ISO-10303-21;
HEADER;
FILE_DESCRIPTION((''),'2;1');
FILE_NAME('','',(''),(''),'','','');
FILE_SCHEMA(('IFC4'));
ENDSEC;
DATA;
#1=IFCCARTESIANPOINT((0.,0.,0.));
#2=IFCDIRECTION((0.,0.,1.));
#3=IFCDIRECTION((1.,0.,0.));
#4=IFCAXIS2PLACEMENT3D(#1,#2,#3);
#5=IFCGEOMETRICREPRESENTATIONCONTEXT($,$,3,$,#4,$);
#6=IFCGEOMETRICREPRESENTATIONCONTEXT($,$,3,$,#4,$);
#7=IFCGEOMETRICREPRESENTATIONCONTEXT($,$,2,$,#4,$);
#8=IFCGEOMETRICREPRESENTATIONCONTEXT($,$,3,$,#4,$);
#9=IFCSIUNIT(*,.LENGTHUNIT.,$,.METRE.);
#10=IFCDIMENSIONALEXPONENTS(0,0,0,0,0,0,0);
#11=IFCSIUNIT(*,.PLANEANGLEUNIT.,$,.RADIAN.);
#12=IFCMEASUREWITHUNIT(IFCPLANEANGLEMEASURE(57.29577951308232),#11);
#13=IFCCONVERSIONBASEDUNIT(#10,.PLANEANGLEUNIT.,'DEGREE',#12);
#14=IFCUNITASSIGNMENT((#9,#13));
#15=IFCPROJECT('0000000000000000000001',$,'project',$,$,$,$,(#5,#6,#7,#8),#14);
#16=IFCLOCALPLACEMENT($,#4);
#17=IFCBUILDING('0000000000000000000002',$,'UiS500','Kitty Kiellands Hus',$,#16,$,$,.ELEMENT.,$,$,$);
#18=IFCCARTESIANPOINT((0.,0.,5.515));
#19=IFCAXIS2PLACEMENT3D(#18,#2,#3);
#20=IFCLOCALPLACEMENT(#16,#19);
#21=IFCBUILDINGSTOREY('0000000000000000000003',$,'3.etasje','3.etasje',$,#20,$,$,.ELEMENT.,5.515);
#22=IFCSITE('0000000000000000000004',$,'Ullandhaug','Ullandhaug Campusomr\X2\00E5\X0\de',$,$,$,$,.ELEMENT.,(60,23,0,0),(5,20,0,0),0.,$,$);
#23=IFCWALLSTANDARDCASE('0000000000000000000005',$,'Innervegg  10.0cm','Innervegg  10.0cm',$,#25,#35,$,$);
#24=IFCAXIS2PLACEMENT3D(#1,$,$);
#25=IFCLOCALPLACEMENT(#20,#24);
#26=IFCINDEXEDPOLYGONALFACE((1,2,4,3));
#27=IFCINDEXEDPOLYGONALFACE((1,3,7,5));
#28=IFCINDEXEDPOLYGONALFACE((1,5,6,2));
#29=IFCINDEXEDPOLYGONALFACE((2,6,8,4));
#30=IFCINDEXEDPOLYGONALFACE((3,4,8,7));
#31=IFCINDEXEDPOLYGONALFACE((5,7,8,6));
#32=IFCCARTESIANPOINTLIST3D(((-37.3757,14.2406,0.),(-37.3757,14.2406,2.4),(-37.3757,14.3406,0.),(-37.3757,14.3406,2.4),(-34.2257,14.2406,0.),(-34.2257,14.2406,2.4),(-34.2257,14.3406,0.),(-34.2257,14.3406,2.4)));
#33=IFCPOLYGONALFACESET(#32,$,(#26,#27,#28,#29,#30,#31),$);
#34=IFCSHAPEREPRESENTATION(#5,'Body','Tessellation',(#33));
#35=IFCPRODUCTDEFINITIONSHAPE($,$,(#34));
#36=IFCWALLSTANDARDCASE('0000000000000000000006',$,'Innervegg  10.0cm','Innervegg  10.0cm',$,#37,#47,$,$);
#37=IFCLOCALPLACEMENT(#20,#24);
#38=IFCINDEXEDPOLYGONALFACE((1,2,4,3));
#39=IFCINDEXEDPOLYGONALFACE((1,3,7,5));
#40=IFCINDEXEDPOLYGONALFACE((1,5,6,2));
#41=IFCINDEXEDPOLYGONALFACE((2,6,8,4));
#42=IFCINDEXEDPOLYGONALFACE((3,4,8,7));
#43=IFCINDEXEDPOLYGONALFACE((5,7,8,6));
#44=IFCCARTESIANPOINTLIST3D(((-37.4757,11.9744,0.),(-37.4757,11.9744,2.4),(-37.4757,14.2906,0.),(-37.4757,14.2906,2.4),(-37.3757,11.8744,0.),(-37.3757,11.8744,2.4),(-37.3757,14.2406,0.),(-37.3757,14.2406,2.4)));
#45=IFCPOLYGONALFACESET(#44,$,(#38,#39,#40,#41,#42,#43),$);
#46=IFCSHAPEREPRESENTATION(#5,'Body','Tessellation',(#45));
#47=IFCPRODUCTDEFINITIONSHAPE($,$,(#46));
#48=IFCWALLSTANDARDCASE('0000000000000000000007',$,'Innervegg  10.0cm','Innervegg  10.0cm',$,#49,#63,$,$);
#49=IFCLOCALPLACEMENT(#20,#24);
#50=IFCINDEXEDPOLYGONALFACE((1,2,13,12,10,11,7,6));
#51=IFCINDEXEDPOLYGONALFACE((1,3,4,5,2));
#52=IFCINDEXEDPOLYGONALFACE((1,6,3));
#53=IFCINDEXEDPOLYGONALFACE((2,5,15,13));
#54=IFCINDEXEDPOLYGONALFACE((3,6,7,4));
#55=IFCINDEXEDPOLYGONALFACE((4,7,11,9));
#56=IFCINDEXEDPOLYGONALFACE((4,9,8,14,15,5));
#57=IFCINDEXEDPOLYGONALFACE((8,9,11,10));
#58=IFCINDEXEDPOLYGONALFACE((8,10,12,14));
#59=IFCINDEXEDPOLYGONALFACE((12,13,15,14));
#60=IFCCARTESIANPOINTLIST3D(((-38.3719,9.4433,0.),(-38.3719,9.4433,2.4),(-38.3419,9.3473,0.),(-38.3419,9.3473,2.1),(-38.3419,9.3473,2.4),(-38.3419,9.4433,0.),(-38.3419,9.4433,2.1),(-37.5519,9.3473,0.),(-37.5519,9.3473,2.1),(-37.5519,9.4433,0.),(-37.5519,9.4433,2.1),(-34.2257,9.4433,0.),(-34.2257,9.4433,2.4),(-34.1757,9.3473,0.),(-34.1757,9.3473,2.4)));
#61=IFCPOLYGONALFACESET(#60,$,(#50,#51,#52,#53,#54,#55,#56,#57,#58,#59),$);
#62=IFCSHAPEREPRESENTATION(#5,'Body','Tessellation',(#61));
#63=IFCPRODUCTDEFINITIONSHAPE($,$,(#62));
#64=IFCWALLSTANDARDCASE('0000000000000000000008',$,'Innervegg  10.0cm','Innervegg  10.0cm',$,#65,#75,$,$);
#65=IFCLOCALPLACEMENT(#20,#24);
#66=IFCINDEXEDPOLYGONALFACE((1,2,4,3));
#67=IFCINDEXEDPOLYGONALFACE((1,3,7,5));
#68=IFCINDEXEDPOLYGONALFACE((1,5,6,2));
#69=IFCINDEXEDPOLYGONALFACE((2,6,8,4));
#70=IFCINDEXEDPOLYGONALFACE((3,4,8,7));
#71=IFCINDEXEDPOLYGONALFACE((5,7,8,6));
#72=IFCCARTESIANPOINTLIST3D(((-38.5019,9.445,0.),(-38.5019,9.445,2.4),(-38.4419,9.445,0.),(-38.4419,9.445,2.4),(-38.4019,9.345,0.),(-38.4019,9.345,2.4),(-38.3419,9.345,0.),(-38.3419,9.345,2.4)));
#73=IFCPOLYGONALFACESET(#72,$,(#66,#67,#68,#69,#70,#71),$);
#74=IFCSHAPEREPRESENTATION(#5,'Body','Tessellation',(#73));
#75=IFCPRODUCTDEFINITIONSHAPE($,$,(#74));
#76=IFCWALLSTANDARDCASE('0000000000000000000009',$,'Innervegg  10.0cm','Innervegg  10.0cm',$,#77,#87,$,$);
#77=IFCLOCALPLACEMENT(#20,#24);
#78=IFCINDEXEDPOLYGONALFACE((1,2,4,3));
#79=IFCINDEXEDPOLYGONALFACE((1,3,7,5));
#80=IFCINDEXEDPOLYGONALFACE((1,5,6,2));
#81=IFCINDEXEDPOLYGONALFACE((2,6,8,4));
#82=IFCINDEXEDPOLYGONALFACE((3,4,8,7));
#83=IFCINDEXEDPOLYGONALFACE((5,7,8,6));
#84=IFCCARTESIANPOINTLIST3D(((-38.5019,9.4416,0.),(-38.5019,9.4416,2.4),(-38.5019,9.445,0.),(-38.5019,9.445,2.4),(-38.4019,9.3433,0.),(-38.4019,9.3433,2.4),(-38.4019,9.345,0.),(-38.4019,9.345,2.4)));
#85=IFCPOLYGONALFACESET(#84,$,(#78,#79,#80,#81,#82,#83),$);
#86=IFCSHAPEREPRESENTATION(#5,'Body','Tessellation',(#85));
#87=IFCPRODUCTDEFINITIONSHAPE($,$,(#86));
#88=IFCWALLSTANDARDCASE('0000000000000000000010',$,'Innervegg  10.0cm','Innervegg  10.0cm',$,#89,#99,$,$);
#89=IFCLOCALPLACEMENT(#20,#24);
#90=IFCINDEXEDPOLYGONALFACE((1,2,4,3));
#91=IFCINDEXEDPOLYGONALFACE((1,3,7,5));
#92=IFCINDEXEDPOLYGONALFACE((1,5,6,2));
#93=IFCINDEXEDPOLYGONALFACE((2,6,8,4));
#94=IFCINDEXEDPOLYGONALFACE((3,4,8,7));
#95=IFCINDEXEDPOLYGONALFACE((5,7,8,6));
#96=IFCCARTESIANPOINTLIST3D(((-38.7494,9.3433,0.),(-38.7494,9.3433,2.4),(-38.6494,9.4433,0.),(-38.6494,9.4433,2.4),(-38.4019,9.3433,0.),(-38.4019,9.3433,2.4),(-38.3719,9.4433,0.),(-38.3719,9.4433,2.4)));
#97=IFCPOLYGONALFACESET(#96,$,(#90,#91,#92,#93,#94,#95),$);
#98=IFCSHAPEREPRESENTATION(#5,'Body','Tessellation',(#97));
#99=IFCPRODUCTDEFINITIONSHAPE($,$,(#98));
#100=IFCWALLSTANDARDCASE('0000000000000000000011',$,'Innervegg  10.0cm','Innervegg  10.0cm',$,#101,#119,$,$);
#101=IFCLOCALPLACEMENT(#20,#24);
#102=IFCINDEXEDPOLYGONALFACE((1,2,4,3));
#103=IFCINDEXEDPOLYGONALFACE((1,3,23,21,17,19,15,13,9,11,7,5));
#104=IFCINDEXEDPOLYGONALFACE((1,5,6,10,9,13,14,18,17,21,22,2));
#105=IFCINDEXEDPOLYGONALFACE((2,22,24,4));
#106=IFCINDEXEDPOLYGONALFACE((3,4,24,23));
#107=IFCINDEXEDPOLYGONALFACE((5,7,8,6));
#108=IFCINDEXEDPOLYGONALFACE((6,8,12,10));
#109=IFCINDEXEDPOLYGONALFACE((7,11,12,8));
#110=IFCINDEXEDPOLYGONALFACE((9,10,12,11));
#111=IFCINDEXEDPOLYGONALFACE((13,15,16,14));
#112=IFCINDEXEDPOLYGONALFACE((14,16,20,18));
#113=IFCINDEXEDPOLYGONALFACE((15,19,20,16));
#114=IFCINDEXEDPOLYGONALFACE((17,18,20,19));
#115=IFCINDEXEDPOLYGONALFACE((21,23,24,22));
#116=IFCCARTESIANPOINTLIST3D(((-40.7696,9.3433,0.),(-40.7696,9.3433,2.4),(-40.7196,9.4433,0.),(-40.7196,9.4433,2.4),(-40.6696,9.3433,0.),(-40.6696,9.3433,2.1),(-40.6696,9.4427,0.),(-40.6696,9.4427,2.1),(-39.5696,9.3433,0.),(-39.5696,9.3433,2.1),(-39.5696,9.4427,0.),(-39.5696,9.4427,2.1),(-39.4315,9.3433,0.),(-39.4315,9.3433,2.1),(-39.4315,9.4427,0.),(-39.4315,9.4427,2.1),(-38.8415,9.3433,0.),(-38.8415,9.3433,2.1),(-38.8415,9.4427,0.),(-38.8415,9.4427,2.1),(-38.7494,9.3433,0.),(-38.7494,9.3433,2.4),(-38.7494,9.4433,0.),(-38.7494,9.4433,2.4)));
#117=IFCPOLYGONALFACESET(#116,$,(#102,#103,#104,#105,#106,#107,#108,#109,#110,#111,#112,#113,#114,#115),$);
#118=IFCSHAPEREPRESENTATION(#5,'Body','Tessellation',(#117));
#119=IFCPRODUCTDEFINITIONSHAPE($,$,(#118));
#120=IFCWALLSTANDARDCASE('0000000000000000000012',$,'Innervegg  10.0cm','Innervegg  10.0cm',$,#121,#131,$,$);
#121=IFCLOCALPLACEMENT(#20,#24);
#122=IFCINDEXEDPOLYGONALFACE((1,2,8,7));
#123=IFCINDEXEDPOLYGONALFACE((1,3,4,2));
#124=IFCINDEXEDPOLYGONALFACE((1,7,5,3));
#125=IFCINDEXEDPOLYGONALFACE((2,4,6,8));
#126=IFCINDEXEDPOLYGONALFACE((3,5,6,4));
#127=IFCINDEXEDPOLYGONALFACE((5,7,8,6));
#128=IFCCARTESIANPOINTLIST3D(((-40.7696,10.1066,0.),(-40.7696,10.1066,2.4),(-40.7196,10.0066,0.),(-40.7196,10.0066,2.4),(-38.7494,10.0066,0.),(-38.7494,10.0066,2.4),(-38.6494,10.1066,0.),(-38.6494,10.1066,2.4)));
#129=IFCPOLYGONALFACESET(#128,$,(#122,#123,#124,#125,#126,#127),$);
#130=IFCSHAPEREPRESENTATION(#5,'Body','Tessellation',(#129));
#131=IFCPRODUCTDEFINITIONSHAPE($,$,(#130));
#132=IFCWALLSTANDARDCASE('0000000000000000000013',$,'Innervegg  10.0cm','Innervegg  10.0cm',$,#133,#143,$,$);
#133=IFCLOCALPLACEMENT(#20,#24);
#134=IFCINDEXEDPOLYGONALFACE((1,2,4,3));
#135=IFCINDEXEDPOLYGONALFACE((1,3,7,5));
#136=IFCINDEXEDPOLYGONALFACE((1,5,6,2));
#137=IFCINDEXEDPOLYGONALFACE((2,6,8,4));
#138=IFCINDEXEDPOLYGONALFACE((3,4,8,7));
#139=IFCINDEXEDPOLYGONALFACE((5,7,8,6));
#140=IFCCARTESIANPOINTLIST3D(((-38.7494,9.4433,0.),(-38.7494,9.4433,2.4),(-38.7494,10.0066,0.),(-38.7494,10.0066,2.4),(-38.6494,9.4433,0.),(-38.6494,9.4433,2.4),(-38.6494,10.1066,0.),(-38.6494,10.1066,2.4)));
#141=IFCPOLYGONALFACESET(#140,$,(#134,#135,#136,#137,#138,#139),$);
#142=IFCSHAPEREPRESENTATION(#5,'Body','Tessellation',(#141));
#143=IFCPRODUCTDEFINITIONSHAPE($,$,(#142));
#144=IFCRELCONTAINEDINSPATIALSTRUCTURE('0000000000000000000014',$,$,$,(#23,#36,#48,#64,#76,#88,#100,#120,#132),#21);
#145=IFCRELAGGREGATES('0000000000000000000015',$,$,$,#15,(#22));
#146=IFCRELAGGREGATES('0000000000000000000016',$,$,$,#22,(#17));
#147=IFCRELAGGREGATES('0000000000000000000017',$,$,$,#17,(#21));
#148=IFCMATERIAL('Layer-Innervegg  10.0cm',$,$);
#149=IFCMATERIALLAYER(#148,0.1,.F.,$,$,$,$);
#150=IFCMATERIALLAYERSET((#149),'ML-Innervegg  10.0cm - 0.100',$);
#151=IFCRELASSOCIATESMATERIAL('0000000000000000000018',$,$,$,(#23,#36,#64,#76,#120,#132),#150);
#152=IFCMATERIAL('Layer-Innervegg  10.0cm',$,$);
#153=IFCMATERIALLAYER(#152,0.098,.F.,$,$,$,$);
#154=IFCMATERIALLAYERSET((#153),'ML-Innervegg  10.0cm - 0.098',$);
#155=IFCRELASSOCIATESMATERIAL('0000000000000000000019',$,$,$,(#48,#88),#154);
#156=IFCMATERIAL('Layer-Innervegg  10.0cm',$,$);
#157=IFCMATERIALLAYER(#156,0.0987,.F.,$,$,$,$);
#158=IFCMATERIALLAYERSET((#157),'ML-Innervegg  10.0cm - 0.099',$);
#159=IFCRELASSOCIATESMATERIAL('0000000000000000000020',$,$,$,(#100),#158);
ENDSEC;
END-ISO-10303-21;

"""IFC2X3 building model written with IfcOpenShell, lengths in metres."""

from ifc_helpers import new_model, entity, si_unit, converted_unit, frame, origin_with_axes, place, context, project, spatial, polyline, outline, extrude, material, layer, layer_set, layer_usage, element, save


model = new_model("IFC2X3")

# Units and contexts
context_of_model_1 = context(None, 3, world=origin_with_axes())
context_of_model_2 = context(None, 3, world=origin_with_axes())
context_of_model_3 = context(None, 2, world=origin_with_axes())
context_of_model_4 = context(None, 3, world=origin_with_axes())
ifc_project = project(units=[si_unit("LENGTHUNIT", "METRE"), converted_unit("PLANEANGLEUNIT", "DEGREE", entity("IfcPlaneAngleMeasure", 57.29577951308232), si_unit("PLANEANGLEUNIT", "RADIAN"), dimensions=[0, 0, 0, 0, 0, 0, 0])], contexts=[context_of_model_1, context_of_model_2, context_of_model_3, context_of_model_4])

# Site, building, storey
site = spatial("IfcSite", under=ifc_project, Name="Ullandhaug", Description="Ullandhaug Campusområde", CompositionType="ELEMENT", RefLatitude=(60, 23, 0, 0), RefLongitude=(5, 20, 0, 0), RefElevation=0.0)
building_placement = place(None, origin_with_axes())
building = spatial("IfcBuilding", under=site, at=building_placement, Name="UiS500", Description="Kitty Kiellands Hus", CompositionType="ELEMENT")
storey_placement = place(building_placement, frame((0.0, 0.0, 5.515), z_axis=(0.0, 0.0, 1.0), x_axis=(1.0, 0.0, 0.0)))
storey = spatial("IfcBuildingStorey", under=building, at=storey_placement, Name="3.etasje", Description="3.etasje", CompositionType="ELEMENT", Elevation=5.515)

# Shared definitions
ifc_material_1 = material(Name="Layer-Innervegg  10.0cm")
ifc_layer_1 = layer(ifc_material_1, 0.1, ventilated=False)
ifc_layer_set_1 = layer_set([ifc_layer_1], Name="ML-Innervegg  10.0cm - 0.100")
ifc_layer_usage_1 = layer_usage(ifc_layer_set_1, "AXIS2", "POSITIVE", 0.0)

# Walls
wall_1_placement = place(storey_placement, frame((-37.3757, 14.2406, 0.0), z_axis=(0.0, 0.0, 1.0), x_axis=(1.0, 0.0, 0.0)))
element("IfcWallStandardCase", 1, at=wall_1_placement, inside=storey, material=ifc_layer_usage_1, Name="Innervegg  10.0cm", Description="Innervegg  10.0cm", context=context_of_model_1, shape_type="SweptSolid", body=[
    extrude(outline(polyline([(0.0, 0.0), (3.15, 0.0), (3.15, 0.1), (0.0, 0.1), (0.0, 0.0)])), origin_with_axes(), (0.0, 0.0, 1.0), 2.4),
])
wall_2_placement = place(storey_placement, frame((-37.3757, 11.8744, 0.0), z_axis=(0.0, 0.0, 1.0), x_axis=(0.0, 1.0, 0.0)))
element("IfcWallStandardCase", 2, at=wall_2_placement, inside=storey, material=ifc_layer_usage_1, Name="Innervegg  10.0cm", Description="Innervegg  10.0cm", context=context_of_model_1, shape_type="SweptSolid", body=[
    extrude(outline(polyline([(0.0, 0.0), (2.3662, 0.0), (2.4162, 0.1), (0.1, 0.1), (0.0, 0.0)])), frame((0.0, 0.0, 0.0), z_axis=(0.0, 0.0, 1.0), x_axis=(1.0, 0.0, 0.0)), (0.0, 0.0, 1.0), 2.4),
])

# Wall, opening
ifc_material_2 = material(Name="Layer-Innervegg  10.0cm")
ifc_layer_2 = layer(ifc_material_2, 0.098, ventilated=False)
ifc_layer_set_2 = layer_set([ifc_layer_2], Name="ML-Innervegg  10.0cm - 0.098")
ifc_layer_usage_2 = layer_usage(ifc_layer_set_2, "AXIS2", "POSITIVE", 0.0)
wall_3_placement = place(storey_placement, frame((-34.2257, 9.4433, 0.0), z_axis=(0.0, 0.0, 1.0), x_axis=(-1.0, 0.0, 0.0)))
wall_3 = element("IfcWallStandardCase", 3, at=wall_3_placement, inside=storey, material=ifc_layer_usage_2, Name="Innervegg  10.0cm", Description="Innervegg  10.0cm", context=context_of_model_1, shape_type="SweptSolid", body=[
    extrude(outline(polyline([(0.0, 0.0), (4.1462, 0.0), (4.1162, 0.096), (-0.05, 0.096), (0.0, 0.0)])), frame((0.0, 0.0, 0.0), z_axis=(0.0, 0.0, 1.0), x_axis=(1.0, 0.0, 0.0)), (0.0, 0.0, 1.0), 2.4),
])
opening_1_placement = place(wall_3_placement, frame((3.3262, 0.096, 0.0), z_axis=(0.0, 0.0, 1.0), x_axis=(1.0, 0.0, 0.0)))
element("IfcOpeningElement", 4, at=opening_1_placement, cuts=wall_3, context=context_of_model_1, shape_type="SweptSolid", body=[
    extrude(outline(polyline([(0.0, 0.0), (2.1, 0.0), (2.1, 0.79), (0.0, 0.79), (0.0, 0.0)])), frame((0.0, 0.0, 0.0), z_axis=(0.0, 1.0, 0.0), x_axis=(0.0, 0.0, 1.0)), (0.0, 0.0, -1.0), 0.0983),
])

# Walls
wall_4_placement = place(storey_placement, frame((-38.4419, 9.445, 0.0), z_axis=(0.0, 0.0, 1.0), x_axis=(-1.0, 0.0, 0.0)))
element("IfcWallStandardCase", 5, at=wall_4_placement, inside=storey, material=ifc_layer_usage_1, Name="Innervegg  10.0cm", Description="Innervegg  10.0cm", context=context_of_model_1, shape_type="SweptSolid", body=[
    extrude(outline(polyline([(0.0, 0.0), (0.06, 0.0), (-0.04, 0.1), (-0.1, 0.1), (0.0, 0.0)])), frame((0.0, 0.0, 0.0), z_axis=(0.0, 0.0, 1.0), x_axis=(1.0, 0.0, 0.0)), (0.0, 0.0, 1.0), 2.4),
])
wall_5_placement = place(storey_placement, frame((-38.5019, 9.445, 0.0), z_axis=(0.0, 0.0, 1.0), x_axis=(0.0, -1.0, 0.0)))
element("IfcWallStandardCase", 6, at=wall_5_placement, inside=storey, material=ifc_layer_usage_1, Name="Innervegg  10.0cm", Description="Innervegg  10.0cm", context=context_of_model_1, shape_type="SweptSolid", body=[
    extrude(outline(polyline([(0.0, 0.0), (0.0033, 0.0), (0.1017, 0.1), (0.1, 0.1), (0.0, 0.0)])), frame((0.0, 0.0, 0.0), z_axis=(0.0, 0.0, 1.0), x_axis=(1.0, 0.0, 0.0)), (0.0, 0.0, 1.0), 2.4),
])
wall_6_placement = place(storey_placement, frame((-38.3719, 9.4433, 0.0), z_axis=(0.0, 0.0, 1.0), x_axis=(-1.0, 0.0, 0.0)))
element("IfcWallStandardCase", 7, at=wall_6_placement, inside=storey, material=ifc_layer_usage_2, Name="Innervegg  10.0cm", Description="Innervegg  10.0cm", context=context_of_model_1, shape_type="SweptSolid", body=[
    extrude(outline(polyline([(0.0, 0.0), (0.2774, 0.0), (0.3774, 0.1), (0.03, 0.1), (0.0, 0.0)])), frame((0.0, 0.0, 0.0), z_axis=(0.0, 0.0, 1.0), x_axis=(1.0, 0.0, 0.0)), (0.0, 0.0, 1.0), 2.4),
])

# Wall, openings
ifc_material_3 = material(Name="Layer-Innervegg  10.0cm")
ifc_layer_3 = layer(ifc_material_3, 0.0987, ventilated=False)
ifc_layer_set_3 = layer_set([ifc_layer_3], Name="ML-Innervegg  10.0cm - 0.099")
ifc_layer_usage_3 = layer_usage(ifc_layer_set_3, "AXIS2", "POSITIVE", 0.0)
wall_7_placement = place(storey_placement, frame((-38.7494, 9.4433, 0.0), z_axis=(0.0, 0.0, 1.0), x_axis=(-1.0, 0.0, 0.0)))
wall_7 = element("IfcWallStandardCase", 8, at=wall_7_placement, inside=storey, material=ifc_layer_usage_3, Name="Innervegg  10.0cm", Description="Innervegg  10.0cm", context=context_of_model_1, shape_type="SweptSolid", body=[
    extrude(outline(polyline([(0.0, 0.0), (1.9702, 0.0), (2.0202, 0.1), (0.0, 0.1), (0.0, 0.0)])), frame((0.0, 0.0, 0.0), z_axis=(0.0, 0.0, 1.0), x_axis=(1.0, 0.0, 0.0)), (0.0, 0.0, 1.0), 2.4),
])
opening_2_placement = place(wall_7_placement, frame((0.0921, 0.1, 0.0), z_axis=(0.0, 0.0, 1.0), x_axis=(1.0, 0.0, 0.0)))
element("IfcOpeningElement", 9, at=opening_2_placement, cuts=wall_7, context=context_of_model_1, shape_type="SweptSolid", body=[
    extrude(outline(polyline([(0.0, 0.0), (2.1, 0.0), (2.1, 0.59), (0.0, 0.59), (0.0, 0.0)])), frame((0.0, 0.0, 0.0), z_axis=(0.0, 1.0, 0.0), x_axis=(0.0, 0.0, 1.0)), (0.0, 0.0, -1.0), 0.0994),
])
opening_3_placement = place(wall_7_placement, frame((0.8202, 0.1, 0.0), z_axis=(0.0, 0.0, 1.0), x_axis=(1.0, 0.0, 0.0)))
element("IfcOpeningElement", 10, at=opening_3_placement, cuts=wall_7, context=context_of_model_1, shape_type="SweptSolid", body=[
    extrude(outline(polyline([(0.0, 0.0), (2.1, 0.0), (2.1, 1.1), (0.0, 1.1), (0.0, 0.0)])), frame((0.0, 0.0, 0.0), z_axis=(0.0, 1.0, 0.0), x_axis=(0.0, 0.0, 1.0)), (0.0, 0.0, -1.0), 0.0994),
])

# Walls
wall_8_placement = place(storey_placement, frame((-40.7196, 10.0066, 0.0), z_axis=(0.0, 0.0, 1.0), x_axis=(1.0, 0.0, 0.0)))
element("IfcWallStandardCase", 11, at=wall_8_placement, inside=storey, material=ifc_layer_usage_1, Name="Innervegg  10.0cm", Description="Innervegg  10.0cm", context=context_of_model_1, shape_type="SweptSolid", body=[
    extrude(outline(polyline([(0.0, 0.0), (1.9702, 0.0), (2.0702, 0.1), (-0.05, 0.1), (0.0, 0.0)])), origin_with_axes(), (0.0, 0.0, 1.0), 2.4),
])
wall_9_placement = place(storey_placement, frame((-38.7494, 10.0066, 0.0), z_axis=(0.0, 0.0, 1.0), x_axis=(0.0, -1.0, 0.0)))
element("IfcWallStandardCase", 12, at=wall_9_placement, inside=storey, material=ifc_layer_usage_1, Name="Innervegg  10.0cm", Description="Innervegg  10.0cm", context=context_of_model_1, shape_type="SweptSolid", body=[
    extrude(outline(polyline([(0.0, 0.0), (0.5633, 0.0), (0.5633, 0.1), (-0.1, 0.1), (0.0, 0.0)])), frame((0.0, 0.0, 0.0), z_axis=(0.0, 0.0, 1.0), x_axis=(1.0, 0.0, 0.0)), (0.0, 0.0, 1.0), 2.4),
])

save(model, "model.ifc")
